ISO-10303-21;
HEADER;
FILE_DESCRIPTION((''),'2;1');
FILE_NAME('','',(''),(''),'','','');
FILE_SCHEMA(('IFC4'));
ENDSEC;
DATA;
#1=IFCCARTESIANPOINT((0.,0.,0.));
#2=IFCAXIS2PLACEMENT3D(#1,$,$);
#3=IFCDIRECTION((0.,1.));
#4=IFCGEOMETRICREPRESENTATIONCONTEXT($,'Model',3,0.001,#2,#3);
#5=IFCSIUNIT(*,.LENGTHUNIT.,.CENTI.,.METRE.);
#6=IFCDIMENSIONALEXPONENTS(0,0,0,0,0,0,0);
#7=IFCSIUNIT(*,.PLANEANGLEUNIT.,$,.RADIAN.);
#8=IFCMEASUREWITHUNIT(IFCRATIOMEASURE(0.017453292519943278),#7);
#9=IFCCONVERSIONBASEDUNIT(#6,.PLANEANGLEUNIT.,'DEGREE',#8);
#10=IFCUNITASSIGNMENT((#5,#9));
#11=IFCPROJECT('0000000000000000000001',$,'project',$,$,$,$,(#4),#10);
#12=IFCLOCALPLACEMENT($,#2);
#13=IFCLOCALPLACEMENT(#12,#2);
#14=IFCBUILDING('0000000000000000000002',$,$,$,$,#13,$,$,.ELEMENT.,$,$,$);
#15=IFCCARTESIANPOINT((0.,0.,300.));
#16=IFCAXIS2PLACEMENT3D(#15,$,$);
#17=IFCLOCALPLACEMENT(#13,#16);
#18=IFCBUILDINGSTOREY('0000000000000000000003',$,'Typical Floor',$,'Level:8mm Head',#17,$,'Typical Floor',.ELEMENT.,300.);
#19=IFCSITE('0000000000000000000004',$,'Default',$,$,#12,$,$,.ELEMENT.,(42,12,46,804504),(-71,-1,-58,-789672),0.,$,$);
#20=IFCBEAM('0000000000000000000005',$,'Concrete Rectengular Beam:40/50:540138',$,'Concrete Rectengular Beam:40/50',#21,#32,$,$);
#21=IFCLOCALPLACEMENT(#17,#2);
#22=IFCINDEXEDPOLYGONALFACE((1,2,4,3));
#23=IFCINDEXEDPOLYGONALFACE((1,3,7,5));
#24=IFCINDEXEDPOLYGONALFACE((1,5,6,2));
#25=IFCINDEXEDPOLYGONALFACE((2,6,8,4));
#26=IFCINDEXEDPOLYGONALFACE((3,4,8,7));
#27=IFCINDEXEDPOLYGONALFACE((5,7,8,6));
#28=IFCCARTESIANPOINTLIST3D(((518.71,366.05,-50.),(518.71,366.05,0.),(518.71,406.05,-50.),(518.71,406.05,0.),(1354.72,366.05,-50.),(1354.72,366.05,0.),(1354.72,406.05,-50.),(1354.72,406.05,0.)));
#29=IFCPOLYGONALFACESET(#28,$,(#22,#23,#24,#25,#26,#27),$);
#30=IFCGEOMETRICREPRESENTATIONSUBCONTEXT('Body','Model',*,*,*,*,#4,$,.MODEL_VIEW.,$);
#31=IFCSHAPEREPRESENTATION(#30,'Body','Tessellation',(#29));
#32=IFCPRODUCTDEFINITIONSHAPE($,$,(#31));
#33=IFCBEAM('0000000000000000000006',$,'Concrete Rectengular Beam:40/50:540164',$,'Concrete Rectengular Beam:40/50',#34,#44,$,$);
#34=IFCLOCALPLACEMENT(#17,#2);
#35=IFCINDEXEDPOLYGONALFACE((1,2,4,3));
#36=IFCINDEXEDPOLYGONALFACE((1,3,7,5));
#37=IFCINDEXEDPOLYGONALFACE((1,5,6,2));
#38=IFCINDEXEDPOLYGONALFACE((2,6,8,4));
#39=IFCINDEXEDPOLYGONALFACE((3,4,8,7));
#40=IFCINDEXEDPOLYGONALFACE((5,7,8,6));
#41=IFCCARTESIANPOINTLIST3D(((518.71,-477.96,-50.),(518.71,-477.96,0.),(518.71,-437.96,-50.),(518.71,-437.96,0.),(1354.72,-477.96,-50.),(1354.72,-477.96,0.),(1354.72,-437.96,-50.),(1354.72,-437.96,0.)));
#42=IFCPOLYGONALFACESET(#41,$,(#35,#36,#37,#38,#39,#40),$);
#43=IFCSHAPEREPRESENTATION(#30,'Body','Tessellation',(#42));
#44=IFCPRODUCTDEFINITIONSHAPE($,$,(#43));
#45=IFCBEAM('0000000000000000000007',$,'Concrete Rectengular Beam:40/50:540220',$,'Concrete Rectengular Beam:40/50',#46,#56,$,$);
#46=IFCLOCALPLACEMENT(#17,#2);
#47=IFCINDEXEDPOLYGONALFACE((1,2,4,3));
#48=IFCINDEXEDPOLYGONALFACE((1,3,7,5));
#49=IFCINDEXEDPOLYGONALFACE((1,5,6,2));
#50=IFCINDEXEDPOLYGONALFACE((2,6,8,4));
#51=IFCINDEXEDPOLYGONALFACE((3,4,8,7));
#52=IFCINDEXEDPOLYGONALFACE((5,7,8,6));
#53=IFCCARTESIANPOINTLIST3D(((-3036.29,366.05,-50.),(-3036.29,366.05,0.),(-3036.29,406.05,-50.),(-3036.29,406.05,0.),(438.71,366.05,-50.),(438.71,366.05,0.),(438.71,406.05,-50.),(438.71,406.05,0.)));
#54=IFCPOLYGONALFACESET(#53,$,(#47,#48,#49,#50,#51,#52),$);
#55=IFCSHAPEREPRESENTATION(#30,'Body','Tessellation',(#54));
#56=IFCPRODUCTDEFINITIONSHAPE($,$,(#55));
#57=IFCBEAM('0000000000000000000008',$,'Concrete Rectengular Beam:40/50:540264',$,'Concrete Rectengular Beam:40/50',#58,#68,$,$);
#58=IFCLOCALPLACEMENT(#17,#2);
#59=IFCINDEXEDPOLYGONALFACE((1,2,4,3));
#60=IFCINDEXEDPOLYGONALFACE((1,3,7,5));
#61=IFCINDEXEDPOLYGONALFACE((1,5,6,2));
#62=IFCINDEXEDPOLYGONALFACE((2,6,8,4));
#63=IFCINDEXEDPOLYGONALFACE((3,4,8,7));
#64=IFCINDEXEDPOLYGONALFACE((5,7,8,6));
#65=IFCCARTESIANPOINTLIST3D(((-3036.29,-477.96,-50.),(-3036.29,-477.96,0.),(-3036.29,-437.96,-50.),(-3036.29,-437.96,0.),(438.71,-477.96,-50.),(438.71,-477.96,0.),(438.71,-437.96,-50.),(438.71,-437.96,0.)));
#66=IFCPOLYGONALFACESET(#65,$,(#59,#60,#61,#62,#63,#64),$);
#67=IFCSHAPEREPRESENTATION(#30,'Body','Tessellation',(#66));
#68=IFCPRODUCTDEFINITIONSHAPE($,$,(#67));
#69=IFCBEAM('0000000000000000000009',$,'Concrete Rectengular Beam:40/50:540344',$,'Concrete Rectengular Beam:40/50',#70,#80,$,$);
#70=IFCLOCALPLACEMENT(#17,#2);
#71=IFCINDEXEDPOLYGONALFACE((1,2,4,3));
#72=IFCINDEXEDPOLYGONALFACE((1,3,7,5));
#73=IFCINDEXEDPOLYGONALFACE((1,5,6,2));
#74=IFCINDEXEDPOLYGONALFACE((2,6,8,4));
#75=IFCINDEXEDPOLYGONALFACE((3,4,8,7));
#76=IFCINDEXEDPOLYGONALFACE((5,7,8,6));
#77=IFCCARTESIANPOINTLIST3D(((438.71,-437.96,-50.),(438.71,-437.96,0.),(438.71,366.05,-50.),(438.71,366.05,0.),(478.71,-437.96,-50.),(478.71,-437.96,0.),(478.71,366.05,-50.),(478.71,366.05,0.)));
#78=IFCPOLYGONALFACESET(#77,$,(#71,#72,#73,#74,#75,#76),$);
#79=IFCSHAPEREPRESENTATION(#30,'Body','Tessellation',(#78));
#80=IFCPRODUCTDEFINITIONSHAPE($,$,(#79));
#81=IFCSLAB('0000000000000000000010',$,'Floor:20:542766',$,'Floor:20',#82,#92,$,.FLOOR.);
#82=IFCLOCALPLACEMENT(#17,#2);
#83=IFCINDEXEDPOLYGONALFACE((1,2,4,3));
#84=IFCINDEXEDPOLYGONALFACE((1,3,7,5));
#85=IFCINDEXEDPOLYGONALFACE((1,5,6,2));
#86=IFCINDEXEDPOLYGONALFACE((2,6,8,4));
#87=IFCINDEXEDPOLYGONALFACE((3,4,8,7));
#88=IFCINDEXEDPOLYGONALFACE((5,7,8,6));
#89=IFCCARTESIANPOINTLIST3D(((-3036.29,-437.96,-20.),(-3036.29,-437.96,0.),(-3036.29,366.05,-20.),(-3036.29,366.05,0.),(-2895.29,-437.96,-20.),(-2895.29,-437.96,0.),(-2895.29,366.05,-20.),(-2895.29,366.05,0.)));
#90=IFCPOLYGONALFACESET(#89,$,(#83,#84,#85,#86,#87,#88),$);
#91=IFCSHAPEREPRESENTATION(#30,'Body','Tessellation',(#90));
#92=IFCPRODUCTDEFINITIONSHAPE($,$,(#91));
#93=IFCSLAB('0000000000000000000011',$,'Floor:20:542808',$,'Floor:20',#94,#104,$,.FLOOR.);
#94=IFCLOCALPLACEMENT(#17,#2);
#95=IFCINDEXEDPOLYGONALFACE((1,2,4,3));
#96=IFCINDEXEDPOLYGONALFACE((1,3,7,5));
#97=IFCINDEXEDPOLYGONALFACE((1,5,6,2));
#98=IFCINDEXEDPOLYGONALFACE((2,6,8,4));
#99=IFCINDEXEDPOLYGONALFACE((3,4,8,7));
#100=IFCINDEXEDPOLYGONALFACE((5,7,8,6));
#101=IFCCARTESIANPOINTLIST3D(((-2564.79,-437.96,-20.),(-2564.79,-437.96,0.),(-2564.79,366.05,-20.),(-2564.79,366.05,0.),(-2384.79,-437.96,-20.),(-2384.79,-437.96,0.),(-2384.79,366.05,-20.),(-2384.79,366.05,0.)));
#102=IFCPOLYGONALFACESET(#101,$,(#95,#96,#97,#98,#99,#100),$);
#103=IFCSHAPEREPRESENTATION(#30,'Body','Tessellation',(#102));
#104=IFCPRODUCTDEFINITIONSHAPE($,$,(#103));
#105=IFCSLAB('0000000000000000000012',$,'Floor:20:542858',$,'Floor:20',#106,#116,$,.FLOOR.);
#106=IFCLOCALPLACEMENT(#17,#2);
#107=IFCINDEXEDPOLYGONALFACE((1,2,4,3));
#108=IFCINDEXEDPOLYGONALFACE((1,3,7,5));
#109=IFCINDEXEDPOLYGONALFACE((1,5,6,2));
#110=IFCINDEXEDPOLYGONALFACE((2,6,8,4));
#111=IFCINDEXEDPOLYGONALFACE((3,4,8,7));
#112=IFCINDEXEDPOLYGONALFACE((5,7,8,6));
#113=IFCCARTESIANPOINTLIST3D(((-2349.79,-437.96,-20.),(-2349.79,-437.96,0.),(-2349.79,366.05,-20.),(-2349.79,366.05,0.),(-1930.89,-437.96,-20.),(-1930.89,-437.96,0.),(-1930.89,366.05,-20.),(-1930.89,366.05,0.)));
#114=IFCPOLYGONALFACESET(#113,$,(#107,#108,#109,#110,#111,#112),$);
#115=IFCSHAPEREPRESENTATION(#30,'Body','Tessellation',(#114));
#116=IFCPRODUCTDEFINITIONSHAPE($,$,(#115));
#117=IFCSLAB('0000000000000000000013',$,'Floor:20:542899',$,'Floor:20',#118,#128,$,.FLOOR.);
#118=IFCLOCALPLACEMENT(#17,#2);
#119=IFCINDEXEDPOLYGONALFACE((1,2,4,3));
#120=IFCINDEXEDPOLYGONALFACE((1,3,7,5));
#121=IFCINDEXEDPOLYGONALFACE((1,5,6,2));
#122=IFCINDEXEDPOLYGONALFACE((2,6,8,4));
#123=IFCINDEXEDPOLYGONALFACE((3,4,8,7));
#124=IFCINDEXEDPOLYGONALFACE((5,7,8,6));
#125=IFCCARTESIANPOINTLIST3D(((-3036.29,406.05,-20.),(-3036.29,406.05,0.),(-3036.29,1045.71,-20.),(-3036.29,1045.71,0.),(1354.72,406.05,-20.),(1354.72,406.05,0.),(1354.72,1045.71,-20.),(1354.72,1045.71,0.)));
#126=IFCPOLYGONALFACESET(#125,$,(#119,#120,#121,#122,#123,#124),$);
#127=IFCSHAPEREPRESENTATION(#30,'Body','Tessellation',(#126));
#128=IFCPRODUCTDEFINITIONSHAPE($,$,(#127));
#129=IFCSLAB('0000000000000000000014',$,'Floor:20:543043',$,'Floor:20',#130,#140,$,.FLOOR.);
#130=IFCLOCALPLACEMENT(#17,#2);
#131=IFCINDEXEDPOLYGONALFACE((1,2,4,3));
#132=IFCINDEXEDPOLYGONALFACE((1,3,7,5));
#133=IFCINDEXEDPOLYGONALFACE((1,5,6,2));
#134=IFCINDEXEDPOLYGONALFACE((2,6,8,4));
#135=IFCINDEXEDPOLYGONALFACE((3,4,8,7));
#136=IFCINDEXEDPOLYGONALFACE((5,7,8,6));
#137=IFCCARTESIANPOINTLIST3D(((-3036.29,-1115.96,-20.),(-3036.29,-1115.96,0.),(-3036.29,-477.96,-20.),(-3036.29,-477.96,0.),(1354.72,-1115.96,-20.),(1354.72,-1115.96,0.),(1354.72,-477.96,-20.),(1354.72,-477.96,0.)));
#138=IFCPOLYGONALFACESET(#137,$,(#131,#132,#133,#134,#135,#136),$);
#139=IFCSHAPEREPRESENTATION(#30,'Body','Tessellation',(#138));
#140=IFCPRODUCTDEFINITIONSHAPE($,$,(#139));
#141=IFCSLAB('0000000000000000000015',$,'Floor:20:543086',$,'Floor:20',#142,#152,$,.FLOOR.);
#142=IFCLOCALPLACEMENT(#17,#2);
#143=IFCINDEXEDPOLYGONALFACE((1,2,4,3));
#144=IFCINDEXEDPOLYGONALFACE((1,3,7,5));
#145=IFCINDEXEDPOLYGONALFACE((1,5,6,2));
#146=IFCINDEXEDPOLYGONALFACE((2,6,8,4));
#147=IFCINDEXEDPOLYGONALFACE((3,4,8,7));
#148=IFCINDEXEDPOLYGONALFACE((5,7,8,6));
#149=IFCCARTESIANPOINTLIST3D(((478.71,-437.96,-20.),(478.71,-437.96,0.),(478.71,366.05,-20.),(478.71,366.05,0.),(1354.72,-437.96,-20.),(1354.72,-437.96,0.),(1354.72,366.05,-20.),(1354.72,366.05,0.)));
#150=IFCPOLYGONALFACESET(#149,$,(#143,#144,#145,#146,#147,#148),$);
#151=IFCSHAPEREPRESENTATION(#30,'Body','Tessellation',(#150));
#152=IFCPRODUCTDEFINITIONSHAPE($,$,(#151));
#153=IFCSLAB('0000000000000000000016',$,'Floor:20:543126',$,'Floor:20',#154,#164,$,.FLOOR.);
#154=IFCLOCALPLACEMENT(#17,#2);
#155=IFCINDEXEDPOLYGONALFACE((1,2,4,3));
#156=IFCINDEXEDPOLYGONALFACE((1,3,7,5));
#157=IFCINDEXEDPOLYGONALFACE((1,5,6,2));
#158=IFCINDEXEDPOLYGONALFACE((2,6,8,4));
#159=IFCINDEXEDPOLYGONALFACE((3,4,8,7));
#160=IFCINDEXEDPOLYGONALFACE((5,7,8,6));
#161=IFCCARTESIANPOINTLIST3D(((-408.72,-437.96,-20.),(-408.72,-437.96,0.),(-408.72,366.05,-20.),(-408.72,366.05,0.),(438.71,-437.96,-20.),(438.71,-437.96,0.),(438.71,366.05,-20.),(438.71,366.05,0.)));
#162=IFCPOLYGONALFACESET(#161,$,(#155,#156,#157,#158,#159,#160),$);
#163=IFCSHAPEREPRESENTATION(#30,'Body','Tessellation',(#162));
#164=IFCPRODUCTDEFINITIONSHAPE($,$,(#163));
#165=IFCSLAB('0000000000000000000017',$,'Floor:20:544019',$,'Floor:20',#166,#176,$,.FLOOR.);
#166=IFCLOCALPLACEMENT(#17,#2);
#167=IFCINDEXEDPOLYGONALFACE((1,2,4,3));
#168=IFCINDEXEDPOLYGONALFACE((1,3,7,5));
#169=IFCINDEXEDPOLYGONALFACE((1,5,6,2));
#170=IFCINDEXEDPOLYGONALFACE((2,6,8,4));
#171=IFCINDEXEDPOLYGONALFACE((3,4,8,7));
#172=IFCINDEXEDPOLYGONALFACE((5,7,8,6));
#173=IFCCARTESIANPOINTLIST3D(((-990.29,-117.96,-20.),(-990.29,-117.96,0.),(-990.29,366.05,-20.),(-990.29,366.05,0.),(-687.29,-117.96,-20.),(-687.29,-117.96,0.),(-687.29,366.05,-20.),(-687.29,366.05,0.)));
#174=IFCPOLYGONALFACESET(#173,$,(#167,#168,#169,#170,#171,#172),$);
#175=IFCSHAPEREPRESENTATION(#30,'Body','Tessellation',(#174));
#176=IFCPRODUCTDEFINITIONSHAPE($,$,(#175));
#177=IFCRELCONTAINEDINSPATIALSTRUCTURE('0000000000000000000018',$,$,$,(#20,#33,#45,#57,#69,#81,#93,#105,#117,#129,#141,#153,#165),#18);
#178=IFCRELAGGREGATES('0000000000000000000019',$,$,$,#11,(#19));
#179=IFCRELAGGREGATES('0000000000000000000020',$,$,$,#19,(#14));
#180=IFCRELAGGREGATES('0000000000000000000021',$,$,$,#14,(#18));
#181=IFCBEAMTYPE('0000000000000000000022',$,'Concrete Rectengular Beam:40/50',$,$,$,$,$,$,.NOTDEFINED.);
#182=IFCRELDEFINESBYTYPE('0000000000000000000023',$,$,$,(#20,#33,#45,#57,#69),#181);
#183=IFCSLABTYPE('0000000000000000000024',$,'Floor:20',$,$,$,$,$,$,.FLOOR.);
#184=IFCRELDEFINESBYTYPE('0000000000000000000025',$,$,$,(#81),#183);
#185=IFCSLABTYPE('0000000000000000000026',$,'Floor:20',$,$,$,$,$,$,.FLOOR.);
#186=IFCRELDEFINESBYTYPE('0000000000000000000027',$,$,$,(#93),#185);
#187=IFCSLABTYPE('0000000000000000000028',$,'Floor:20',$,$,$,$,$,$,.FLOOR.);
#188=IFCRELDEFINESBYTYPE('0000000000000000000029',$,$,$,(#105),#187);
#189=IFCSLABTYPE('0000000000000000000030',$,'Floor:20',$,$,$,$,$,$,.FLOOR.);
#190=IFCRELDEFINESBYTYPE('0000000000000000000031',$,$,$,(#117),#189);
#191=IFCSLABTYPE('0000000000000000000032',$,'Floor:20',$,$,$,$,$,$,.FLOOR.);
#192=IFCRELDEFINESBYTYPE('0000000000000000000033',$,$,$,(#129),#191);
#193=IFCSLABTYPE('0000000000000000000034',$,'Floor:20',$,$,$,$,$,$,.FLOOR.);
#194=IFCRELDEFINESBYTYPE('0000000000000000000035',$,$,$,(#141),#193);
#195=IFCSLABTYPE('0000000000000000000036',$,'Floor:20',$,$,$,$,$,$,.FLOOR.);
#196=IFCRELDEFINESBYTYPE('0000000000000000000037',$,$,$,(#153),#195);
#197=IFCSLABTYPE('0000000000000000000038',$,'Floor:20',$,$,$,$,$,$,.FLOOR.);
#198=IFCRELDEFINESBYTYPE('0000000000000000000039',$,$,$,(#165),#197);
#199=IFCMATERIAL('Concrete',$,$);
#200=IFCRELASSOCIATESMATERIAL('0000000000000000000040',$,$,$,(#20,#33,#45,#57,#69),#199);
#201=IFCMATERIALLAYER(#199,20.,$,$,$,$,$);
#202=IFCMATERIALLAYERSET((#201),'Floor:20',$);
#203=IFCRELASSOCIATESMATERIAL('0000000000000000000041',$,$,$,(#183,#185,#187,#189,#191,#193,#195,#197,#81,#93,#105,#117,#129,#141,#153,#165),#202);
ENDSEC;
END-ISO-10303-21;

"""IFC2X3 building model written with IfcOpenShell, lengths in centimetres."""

from ifc_helpers import new_model, entity, si_unit, converted_unit, direction, frame, frame_2d, origin, origin_2d_with_axis, place, context, subcontext, project, spatial, rectangle, extrude, material, layer, layer_set, layer_usage, type_object, element, save


model = new_model("IFC2X3")

# Units and contexts
model_context = context("Model", 3, precision=0.001, world=origin(), true_north=direction((0.0, 1.0)))
body_context = subcontext(model_context, "Body", "Model", "MODEL_VIEW")
ifc_project = project(units=[si_unit("LENGTHUNIT", "METRE", prefix="CENTI"), converted_unit("PLANEANGLEUNIT", "DEGREE", entity("IfcRatioMeasure", 0.017453292519943278), si_unit("PLANEANGLEUNIT", "RADIAN"), dimensions=[0, 0, 0, 0, 0, 0, 0])], contexts=[model_context])

# Site, building, storey
site_placement = place(None, origin())
site = spatial("IfcSite", under=ifc_project, at=site_placement, Name="Default", CompositionType="ELEMENT", RefLatitude=(42, 12, 46, 804504), RefLongitude=(-71, -1, -58, -789672), RefElevation=0.0)
building_placement = place(site_placement, origin())
building = spatial("IfcBuilding", under=site, at=building_placement, CompositionType="ELEMENT")
storey_placement = place(building_placement, frame((0.0, 0.0, 300.0)))
storey = spatial("IfcBuildingStorey", under=building, at=storey_placement, Name="Typical Floor", ObjectType="Level:8mm Head", LongName="Typical Floor", CompositionType="ELEMENT", Elevation=300.0)

# Beams
ifc_material = material(Name="Concrete")
beam_type_1 = type_object("IfcBeamType", Name="Concrete Rectengular Beam:40/50", PredefinedType="NOTDEFINED")
for number, where, name in (
    (1, (478.71, 386.05, 0.0), "Concrete Rectengular Beam:40/50:540138"),
    (2, (478.71, -457.96, 0.0), "Concrete Rectengular Beam:40/50:540164"),
):
    element("IfcBeam", number, at=place(storey_placement, frame(where)), inside=storey, type_object=beam_type_1, material=ifc_material, Name=name, ObjectType="Concrete Rectengular Beam:40/50", context=body_context, shape_type="SweptSolid", body=[
        extrude(rectangle(XDim=50.0, YDim=40.0, at=frame_2d((0.0, 0.0), x_axis=(1.0, 0.0))), frame((40.0, 0.0, -25.0), z_axis=(1.0, 0.0, 0.0), x_axis=(0.0, 0.0, -1.0)), (0.0, 0.0, 1.0), 836.0),
    ])
beam_1_placement = place(storey_placement, frame((478.71, 386.05, 0.0), z_axis=(0.0, 0.0, 1.0), x_axis=(-1.0, 0.0, 0.0)))
element("IfcBeam", 3, at=beam_1_placement, inside=storey, type_object=beam_type_1, material=ifc_material, Name="Concrete Rectengular Beam:40/50:540220", ObjectType="Concrete Rectengular Beam:40/50", context=body_context, shape_type="SweptSolid", body=[
    extrude(rectangle(XDim=50.0, YDim=40.0, at=frame_2d((0.0, 0.0), x_axis=(1.0, 0.0))), frame((40.0, 0.0, -25.0), z_axis=(1.0, 0.0, 0.0), x_axis=(0.0, 0.0, -1.0)), (0.0, 0.0, 1.0), 3475.0),
])
beam_2_placement = place(storey_placement, frame((478.71, -457.96, 0.0), z_axis=(0.0, 0.0, 1.0), x_axis=(-1.0, 0.0, 0.0)))
element("IfcBeam", 4, at=beam_2_placement, inside=storey, type_object=beam_type_1, material=ifc_material, Name="Concrete Rectengular Beam:40/50:540264", ObjectType="Concrete Rectengular Beam:40/50", context=body_context, shape_type="SweptSolid", body=[
    extrude(rectangle(XDim=50.0, YDim=40.0, at=frame_2d((0.0, 0.0), x_axis=(1.0, 0.0))), frame((40.0, 0.0, -25.0), z_axis=(1.0, 0.0, 0.0), x_axis=(0.0, 0.0, -1.0)), (0.0, 0.0, 1.0), 3475.0),
])
beam_3_placement = place(storey_placement, frame((458.71, 386.05, 0.0), z_axis=(0.0, 0.0, 1.0), x_axis=(0.0, -1.0, 0.0)))
element("IfcBeam", 5, at=beam_3_placement, inside=storey, type_object=beam_type_1, material=ifc_material, Name="Concrete Rectengular Beam:40/50:540344", ObjectType="Concrete Rectengular Beam:40/50", context=body_context, shape_type="SweptSolid", body=[
    extrude(rectangle(XDim=50.0, YDim=40.0, at=frame_2d((0.0, 0.0), x_axis=(1.0, 0.0))), frame((20.0, 0.0, -25.0), z_axis=(1.0, 0.0, 0.0), x_axis=(0.0, 0.0, -1.0)), (0.0, 0.0, 1.0), 804.0),
])

# Slabs
ifc_layer = layer(ifc_material, 20.0)
ifc_layer_set = layer_set([ifc_layer], Name="Floor:20")
ifc_layer_usage_1 = layer_usage(ifc_layer_set, "AXIS3", "POSITIVE", 0.0)
slab_type_1 = type_object("IfcSlabType", Name="Floor:20", PredefinedType="FLOOR", material=ifc_layer_set)
slab_1_placement = place(storey_placement, origin())
element("IfcSlab", 6, at=slab_1_placement, inside=storey, type_object=slab_type_1, material=ifc_layer_usage_1, Name="Floor:20:542766", ObjectType="Floor:20", PredefinedType="FLOOR", context=body_context, shape_type="SweptSolid", body=[
    extrude(rectangle(XDim=804.0, YDim=141.0, at=frame_2d((0.0, 0.0), x_axis=(1.0, 0.0))), frame((-2965.79, -35.95, 0.0), z_axis=(0.0, 0.0, -1.0), x_axis=(0.0, 1.0, 0.0)), (0.0, 0.0, 1.0), 20.0),
])
ifc_layer_usage_2 = layer_usage(ifc_layer_set, "AXIS3", "POSITIVE", 0.0)
slab_type_2 = type_object("IfcSlabType", Name="Floor:20", PredefinedType="FLOOR", material=ifc_layer_set)
slab_2_placement = place(storey_placement, origin())
element("IfcSlab", 7, at=slab_2_placement, inside=storey, type_object=slab_type_2, material=ifc_layer_usage_2, Name="Floor:20:542808", ObjectType="Floor:20", PredefinedType="FLOOR", context=body_context, shape_type="SweptSolid", body=[
    extrude(rectangle(XDim=804.0, YDim=180.0, at=origin_2d_with_axis()), frame((-2474.79, -35.95, 0.0), z_axis=(0.0, 0.0, -1.0), x_axis=(0.0, 1.0, 0.0)), (0.0, 0.0, 1.0), 20.0),
])
ifc_layer_usage_3 = layer_usage(ifc_layer_set, "AXIS3", "POSITIVE", 0.0)
slab_type_3 = type_object("IfcSlabType", Name="Floor:20", PredefinedType="FLOOR", material=ifc_layer_set)
slab_3_placement = place(storey_placement, origin())
element("IfcSlab", 8, at=slab_3_placement, inside=storey, type_object=slab_type_3, material=ifc_layer_usage_3, Name="Floor:20:542858", ObjectType="Floor:20", PredefinedType="FLOOR", context=body_context, shape_type="SweptSolid", body=[
    extrude(rectangle(XDim=804.0, YDim=418.9, at=origin_2d_with_axis()), frame((-2140.34, -35.95, 0.0), z_axis=(0.0, 0.0, -1.0), x_axis=(0.0, 1.0, 0.0)), (0.0, 0.0, 1.0), 20.0),
])
ifc_layer_usage_4 = layer_usage(ifc_layer_set, "AXIS3", "POSITIVE", 0.0)
slab_type_4 = type_object("IfcSlabType", Name="Floor:20", PredefinedType="FLOOR", material=ifc_layer_set)
slab_4_placement = place(storey_placement, origin())
element("IfcSlab", 9, at=slab_4_placement, inside=storey, type_object=slab_type_4, material=ifc_layer_usage_4, Name="Floor:20:542899", ObjectType="Floor:20", PredefinedType="FLOOR", context=body_context, shape_type="SweptSolid", body=[
    extrude(rectangle(XDim=639.67, YDim=4391.0, at=frame_2d((0.0, 0.0), x_axis=(1.0, 0.0))), frame((-840.79, 725.88, 0.0), z_axis=(0.0, 0.0, -1.0), x_axis=(0.0, 1.0, 0.0)), (0.0, 0.0, 1.0), 20.0),
])
ifc_layer_usage_5 = layer_usage(ifc_layer_set, "AXIS3", "POSITIVE", 0.0)
slab_type_5 = type_object("IfcSlabType", Name="Floor:20", PredefinedType="FLOOR", material=ifc_layer_set)
slab_5_placement = place(storey_placement, origin())
element("IfcSlab", 10, at=slab_5_placement, inside=storey, type_object=slab_type_5, material=ifc_layer_usage_5, Name="Floor:20:543043", ObjectType="Floor:20", PredefinedType="FLOOR", context=body_context, shape_type="SweptSolid", body=[
    extrude(rectangle(XDim=638.0, YDim=4391.0, at=frame_2d((0.0, 0.0), x_axis=(1.0, 0.0))), frame((-840.79, -796.96, 0.0), z_axis=(0.0, 0.0, -1.0), x_axis=(0.0, 1.0, 0.0)), (0.0, 0.0, 1.0), 20.0),
])
ifc_layer_usage_6 = layer_usage(ifc_layer_set, "AXIS3", "POSITIVE", 0.0)
slab_type_6 = type_object("IfcSlabType", Name="Floor:20", PredefinedType="FLOOR", material=ifc_layer_set)
slab_6_placement = place(storey_placement, origin())
element("IfcSlab", 11, at=slab_6_placement, inside=storey, type_object=slab_type_6, material=ifc_layer_usage_6, Name="Floor:20:543086", ObjectType="Floor:20", PredefinedType="FLOOR", context=body_context, shape_type="SweptSolid", body=[
    extrude(rectangle(XDim=804.0, YDim=876.0, at=origin_2d_with_axis()), frame((916.71, -35.95, 0.0), z_axis=(0.0, 0.0, -1.0), x_axis=(0.0, 1.0, 0.0)), (0.0, 0.0, 1.0), 20.0),
])
ifc_layer_usage_7 = layer_usage(ifc_layer_set, "AXIS3", "POSITIVE", 0.0)
slab_type_7 = type_object("IfcSlabType", Name="Floor:20", PredefinedType="FLOOR", material=ifc_layer_set)
slab_7_placement = place(storey_placement, origin())
element("IfcSlab", 12, at=slab_7_placement, inside=storey, type_object=slab_type_7, material=ifc_layer_usage_7, Name="Floor:20:543126", ObjectType="Floor:20", PredefinedType="FLOOR", context=body_context, shape_type="SweptSolid", body=[
    extrude(rectangle(XDim=804.0, YDim=847.44, at=origin_2d_with_axis()), frame((14.99, -35.95, 0.0), z_axis=(0.0, 0.0, -1.0), x_axis=(0.0, 1.0, 0.0)), (0.0, 0.0, 1.0), 20.0),
])
ifc_layer_usage_8 = layer_usage(ifc_layer_set, "AXIS3", "POSITIVE", 0.0)
slab_type_8 = type_object("IfcSlabType", Name="Floor:20", PredefinedType="FLOOR", material=ifc_layer_set)
slab_8_placement = place(storey_placement, origin())
element("IfcSlab", 13, at=slab_8_placement, inside=storey, type_object=slab_type_8, material=ifc_layer_usage_8, Name="Floor:20:544019", ObjectType="Floor:20", PredefinedType="FLOOR", context=body_context, shape_type="SweptSolid", body=[
    extrude(rectangle(XDim=484.0, YDim=303.0, at=frame_2d((0.0, 0.0), x_axis=(1.0, 0.0))), frame((-838.79, 124.05, 0.0), z_axis=(0.0, 0.0, -1.0), x_axis=(0.0, 1.0, 0.0)), (0.0, 0.0, 1.0), 20.0),
])

save(model, "model.ifc")
